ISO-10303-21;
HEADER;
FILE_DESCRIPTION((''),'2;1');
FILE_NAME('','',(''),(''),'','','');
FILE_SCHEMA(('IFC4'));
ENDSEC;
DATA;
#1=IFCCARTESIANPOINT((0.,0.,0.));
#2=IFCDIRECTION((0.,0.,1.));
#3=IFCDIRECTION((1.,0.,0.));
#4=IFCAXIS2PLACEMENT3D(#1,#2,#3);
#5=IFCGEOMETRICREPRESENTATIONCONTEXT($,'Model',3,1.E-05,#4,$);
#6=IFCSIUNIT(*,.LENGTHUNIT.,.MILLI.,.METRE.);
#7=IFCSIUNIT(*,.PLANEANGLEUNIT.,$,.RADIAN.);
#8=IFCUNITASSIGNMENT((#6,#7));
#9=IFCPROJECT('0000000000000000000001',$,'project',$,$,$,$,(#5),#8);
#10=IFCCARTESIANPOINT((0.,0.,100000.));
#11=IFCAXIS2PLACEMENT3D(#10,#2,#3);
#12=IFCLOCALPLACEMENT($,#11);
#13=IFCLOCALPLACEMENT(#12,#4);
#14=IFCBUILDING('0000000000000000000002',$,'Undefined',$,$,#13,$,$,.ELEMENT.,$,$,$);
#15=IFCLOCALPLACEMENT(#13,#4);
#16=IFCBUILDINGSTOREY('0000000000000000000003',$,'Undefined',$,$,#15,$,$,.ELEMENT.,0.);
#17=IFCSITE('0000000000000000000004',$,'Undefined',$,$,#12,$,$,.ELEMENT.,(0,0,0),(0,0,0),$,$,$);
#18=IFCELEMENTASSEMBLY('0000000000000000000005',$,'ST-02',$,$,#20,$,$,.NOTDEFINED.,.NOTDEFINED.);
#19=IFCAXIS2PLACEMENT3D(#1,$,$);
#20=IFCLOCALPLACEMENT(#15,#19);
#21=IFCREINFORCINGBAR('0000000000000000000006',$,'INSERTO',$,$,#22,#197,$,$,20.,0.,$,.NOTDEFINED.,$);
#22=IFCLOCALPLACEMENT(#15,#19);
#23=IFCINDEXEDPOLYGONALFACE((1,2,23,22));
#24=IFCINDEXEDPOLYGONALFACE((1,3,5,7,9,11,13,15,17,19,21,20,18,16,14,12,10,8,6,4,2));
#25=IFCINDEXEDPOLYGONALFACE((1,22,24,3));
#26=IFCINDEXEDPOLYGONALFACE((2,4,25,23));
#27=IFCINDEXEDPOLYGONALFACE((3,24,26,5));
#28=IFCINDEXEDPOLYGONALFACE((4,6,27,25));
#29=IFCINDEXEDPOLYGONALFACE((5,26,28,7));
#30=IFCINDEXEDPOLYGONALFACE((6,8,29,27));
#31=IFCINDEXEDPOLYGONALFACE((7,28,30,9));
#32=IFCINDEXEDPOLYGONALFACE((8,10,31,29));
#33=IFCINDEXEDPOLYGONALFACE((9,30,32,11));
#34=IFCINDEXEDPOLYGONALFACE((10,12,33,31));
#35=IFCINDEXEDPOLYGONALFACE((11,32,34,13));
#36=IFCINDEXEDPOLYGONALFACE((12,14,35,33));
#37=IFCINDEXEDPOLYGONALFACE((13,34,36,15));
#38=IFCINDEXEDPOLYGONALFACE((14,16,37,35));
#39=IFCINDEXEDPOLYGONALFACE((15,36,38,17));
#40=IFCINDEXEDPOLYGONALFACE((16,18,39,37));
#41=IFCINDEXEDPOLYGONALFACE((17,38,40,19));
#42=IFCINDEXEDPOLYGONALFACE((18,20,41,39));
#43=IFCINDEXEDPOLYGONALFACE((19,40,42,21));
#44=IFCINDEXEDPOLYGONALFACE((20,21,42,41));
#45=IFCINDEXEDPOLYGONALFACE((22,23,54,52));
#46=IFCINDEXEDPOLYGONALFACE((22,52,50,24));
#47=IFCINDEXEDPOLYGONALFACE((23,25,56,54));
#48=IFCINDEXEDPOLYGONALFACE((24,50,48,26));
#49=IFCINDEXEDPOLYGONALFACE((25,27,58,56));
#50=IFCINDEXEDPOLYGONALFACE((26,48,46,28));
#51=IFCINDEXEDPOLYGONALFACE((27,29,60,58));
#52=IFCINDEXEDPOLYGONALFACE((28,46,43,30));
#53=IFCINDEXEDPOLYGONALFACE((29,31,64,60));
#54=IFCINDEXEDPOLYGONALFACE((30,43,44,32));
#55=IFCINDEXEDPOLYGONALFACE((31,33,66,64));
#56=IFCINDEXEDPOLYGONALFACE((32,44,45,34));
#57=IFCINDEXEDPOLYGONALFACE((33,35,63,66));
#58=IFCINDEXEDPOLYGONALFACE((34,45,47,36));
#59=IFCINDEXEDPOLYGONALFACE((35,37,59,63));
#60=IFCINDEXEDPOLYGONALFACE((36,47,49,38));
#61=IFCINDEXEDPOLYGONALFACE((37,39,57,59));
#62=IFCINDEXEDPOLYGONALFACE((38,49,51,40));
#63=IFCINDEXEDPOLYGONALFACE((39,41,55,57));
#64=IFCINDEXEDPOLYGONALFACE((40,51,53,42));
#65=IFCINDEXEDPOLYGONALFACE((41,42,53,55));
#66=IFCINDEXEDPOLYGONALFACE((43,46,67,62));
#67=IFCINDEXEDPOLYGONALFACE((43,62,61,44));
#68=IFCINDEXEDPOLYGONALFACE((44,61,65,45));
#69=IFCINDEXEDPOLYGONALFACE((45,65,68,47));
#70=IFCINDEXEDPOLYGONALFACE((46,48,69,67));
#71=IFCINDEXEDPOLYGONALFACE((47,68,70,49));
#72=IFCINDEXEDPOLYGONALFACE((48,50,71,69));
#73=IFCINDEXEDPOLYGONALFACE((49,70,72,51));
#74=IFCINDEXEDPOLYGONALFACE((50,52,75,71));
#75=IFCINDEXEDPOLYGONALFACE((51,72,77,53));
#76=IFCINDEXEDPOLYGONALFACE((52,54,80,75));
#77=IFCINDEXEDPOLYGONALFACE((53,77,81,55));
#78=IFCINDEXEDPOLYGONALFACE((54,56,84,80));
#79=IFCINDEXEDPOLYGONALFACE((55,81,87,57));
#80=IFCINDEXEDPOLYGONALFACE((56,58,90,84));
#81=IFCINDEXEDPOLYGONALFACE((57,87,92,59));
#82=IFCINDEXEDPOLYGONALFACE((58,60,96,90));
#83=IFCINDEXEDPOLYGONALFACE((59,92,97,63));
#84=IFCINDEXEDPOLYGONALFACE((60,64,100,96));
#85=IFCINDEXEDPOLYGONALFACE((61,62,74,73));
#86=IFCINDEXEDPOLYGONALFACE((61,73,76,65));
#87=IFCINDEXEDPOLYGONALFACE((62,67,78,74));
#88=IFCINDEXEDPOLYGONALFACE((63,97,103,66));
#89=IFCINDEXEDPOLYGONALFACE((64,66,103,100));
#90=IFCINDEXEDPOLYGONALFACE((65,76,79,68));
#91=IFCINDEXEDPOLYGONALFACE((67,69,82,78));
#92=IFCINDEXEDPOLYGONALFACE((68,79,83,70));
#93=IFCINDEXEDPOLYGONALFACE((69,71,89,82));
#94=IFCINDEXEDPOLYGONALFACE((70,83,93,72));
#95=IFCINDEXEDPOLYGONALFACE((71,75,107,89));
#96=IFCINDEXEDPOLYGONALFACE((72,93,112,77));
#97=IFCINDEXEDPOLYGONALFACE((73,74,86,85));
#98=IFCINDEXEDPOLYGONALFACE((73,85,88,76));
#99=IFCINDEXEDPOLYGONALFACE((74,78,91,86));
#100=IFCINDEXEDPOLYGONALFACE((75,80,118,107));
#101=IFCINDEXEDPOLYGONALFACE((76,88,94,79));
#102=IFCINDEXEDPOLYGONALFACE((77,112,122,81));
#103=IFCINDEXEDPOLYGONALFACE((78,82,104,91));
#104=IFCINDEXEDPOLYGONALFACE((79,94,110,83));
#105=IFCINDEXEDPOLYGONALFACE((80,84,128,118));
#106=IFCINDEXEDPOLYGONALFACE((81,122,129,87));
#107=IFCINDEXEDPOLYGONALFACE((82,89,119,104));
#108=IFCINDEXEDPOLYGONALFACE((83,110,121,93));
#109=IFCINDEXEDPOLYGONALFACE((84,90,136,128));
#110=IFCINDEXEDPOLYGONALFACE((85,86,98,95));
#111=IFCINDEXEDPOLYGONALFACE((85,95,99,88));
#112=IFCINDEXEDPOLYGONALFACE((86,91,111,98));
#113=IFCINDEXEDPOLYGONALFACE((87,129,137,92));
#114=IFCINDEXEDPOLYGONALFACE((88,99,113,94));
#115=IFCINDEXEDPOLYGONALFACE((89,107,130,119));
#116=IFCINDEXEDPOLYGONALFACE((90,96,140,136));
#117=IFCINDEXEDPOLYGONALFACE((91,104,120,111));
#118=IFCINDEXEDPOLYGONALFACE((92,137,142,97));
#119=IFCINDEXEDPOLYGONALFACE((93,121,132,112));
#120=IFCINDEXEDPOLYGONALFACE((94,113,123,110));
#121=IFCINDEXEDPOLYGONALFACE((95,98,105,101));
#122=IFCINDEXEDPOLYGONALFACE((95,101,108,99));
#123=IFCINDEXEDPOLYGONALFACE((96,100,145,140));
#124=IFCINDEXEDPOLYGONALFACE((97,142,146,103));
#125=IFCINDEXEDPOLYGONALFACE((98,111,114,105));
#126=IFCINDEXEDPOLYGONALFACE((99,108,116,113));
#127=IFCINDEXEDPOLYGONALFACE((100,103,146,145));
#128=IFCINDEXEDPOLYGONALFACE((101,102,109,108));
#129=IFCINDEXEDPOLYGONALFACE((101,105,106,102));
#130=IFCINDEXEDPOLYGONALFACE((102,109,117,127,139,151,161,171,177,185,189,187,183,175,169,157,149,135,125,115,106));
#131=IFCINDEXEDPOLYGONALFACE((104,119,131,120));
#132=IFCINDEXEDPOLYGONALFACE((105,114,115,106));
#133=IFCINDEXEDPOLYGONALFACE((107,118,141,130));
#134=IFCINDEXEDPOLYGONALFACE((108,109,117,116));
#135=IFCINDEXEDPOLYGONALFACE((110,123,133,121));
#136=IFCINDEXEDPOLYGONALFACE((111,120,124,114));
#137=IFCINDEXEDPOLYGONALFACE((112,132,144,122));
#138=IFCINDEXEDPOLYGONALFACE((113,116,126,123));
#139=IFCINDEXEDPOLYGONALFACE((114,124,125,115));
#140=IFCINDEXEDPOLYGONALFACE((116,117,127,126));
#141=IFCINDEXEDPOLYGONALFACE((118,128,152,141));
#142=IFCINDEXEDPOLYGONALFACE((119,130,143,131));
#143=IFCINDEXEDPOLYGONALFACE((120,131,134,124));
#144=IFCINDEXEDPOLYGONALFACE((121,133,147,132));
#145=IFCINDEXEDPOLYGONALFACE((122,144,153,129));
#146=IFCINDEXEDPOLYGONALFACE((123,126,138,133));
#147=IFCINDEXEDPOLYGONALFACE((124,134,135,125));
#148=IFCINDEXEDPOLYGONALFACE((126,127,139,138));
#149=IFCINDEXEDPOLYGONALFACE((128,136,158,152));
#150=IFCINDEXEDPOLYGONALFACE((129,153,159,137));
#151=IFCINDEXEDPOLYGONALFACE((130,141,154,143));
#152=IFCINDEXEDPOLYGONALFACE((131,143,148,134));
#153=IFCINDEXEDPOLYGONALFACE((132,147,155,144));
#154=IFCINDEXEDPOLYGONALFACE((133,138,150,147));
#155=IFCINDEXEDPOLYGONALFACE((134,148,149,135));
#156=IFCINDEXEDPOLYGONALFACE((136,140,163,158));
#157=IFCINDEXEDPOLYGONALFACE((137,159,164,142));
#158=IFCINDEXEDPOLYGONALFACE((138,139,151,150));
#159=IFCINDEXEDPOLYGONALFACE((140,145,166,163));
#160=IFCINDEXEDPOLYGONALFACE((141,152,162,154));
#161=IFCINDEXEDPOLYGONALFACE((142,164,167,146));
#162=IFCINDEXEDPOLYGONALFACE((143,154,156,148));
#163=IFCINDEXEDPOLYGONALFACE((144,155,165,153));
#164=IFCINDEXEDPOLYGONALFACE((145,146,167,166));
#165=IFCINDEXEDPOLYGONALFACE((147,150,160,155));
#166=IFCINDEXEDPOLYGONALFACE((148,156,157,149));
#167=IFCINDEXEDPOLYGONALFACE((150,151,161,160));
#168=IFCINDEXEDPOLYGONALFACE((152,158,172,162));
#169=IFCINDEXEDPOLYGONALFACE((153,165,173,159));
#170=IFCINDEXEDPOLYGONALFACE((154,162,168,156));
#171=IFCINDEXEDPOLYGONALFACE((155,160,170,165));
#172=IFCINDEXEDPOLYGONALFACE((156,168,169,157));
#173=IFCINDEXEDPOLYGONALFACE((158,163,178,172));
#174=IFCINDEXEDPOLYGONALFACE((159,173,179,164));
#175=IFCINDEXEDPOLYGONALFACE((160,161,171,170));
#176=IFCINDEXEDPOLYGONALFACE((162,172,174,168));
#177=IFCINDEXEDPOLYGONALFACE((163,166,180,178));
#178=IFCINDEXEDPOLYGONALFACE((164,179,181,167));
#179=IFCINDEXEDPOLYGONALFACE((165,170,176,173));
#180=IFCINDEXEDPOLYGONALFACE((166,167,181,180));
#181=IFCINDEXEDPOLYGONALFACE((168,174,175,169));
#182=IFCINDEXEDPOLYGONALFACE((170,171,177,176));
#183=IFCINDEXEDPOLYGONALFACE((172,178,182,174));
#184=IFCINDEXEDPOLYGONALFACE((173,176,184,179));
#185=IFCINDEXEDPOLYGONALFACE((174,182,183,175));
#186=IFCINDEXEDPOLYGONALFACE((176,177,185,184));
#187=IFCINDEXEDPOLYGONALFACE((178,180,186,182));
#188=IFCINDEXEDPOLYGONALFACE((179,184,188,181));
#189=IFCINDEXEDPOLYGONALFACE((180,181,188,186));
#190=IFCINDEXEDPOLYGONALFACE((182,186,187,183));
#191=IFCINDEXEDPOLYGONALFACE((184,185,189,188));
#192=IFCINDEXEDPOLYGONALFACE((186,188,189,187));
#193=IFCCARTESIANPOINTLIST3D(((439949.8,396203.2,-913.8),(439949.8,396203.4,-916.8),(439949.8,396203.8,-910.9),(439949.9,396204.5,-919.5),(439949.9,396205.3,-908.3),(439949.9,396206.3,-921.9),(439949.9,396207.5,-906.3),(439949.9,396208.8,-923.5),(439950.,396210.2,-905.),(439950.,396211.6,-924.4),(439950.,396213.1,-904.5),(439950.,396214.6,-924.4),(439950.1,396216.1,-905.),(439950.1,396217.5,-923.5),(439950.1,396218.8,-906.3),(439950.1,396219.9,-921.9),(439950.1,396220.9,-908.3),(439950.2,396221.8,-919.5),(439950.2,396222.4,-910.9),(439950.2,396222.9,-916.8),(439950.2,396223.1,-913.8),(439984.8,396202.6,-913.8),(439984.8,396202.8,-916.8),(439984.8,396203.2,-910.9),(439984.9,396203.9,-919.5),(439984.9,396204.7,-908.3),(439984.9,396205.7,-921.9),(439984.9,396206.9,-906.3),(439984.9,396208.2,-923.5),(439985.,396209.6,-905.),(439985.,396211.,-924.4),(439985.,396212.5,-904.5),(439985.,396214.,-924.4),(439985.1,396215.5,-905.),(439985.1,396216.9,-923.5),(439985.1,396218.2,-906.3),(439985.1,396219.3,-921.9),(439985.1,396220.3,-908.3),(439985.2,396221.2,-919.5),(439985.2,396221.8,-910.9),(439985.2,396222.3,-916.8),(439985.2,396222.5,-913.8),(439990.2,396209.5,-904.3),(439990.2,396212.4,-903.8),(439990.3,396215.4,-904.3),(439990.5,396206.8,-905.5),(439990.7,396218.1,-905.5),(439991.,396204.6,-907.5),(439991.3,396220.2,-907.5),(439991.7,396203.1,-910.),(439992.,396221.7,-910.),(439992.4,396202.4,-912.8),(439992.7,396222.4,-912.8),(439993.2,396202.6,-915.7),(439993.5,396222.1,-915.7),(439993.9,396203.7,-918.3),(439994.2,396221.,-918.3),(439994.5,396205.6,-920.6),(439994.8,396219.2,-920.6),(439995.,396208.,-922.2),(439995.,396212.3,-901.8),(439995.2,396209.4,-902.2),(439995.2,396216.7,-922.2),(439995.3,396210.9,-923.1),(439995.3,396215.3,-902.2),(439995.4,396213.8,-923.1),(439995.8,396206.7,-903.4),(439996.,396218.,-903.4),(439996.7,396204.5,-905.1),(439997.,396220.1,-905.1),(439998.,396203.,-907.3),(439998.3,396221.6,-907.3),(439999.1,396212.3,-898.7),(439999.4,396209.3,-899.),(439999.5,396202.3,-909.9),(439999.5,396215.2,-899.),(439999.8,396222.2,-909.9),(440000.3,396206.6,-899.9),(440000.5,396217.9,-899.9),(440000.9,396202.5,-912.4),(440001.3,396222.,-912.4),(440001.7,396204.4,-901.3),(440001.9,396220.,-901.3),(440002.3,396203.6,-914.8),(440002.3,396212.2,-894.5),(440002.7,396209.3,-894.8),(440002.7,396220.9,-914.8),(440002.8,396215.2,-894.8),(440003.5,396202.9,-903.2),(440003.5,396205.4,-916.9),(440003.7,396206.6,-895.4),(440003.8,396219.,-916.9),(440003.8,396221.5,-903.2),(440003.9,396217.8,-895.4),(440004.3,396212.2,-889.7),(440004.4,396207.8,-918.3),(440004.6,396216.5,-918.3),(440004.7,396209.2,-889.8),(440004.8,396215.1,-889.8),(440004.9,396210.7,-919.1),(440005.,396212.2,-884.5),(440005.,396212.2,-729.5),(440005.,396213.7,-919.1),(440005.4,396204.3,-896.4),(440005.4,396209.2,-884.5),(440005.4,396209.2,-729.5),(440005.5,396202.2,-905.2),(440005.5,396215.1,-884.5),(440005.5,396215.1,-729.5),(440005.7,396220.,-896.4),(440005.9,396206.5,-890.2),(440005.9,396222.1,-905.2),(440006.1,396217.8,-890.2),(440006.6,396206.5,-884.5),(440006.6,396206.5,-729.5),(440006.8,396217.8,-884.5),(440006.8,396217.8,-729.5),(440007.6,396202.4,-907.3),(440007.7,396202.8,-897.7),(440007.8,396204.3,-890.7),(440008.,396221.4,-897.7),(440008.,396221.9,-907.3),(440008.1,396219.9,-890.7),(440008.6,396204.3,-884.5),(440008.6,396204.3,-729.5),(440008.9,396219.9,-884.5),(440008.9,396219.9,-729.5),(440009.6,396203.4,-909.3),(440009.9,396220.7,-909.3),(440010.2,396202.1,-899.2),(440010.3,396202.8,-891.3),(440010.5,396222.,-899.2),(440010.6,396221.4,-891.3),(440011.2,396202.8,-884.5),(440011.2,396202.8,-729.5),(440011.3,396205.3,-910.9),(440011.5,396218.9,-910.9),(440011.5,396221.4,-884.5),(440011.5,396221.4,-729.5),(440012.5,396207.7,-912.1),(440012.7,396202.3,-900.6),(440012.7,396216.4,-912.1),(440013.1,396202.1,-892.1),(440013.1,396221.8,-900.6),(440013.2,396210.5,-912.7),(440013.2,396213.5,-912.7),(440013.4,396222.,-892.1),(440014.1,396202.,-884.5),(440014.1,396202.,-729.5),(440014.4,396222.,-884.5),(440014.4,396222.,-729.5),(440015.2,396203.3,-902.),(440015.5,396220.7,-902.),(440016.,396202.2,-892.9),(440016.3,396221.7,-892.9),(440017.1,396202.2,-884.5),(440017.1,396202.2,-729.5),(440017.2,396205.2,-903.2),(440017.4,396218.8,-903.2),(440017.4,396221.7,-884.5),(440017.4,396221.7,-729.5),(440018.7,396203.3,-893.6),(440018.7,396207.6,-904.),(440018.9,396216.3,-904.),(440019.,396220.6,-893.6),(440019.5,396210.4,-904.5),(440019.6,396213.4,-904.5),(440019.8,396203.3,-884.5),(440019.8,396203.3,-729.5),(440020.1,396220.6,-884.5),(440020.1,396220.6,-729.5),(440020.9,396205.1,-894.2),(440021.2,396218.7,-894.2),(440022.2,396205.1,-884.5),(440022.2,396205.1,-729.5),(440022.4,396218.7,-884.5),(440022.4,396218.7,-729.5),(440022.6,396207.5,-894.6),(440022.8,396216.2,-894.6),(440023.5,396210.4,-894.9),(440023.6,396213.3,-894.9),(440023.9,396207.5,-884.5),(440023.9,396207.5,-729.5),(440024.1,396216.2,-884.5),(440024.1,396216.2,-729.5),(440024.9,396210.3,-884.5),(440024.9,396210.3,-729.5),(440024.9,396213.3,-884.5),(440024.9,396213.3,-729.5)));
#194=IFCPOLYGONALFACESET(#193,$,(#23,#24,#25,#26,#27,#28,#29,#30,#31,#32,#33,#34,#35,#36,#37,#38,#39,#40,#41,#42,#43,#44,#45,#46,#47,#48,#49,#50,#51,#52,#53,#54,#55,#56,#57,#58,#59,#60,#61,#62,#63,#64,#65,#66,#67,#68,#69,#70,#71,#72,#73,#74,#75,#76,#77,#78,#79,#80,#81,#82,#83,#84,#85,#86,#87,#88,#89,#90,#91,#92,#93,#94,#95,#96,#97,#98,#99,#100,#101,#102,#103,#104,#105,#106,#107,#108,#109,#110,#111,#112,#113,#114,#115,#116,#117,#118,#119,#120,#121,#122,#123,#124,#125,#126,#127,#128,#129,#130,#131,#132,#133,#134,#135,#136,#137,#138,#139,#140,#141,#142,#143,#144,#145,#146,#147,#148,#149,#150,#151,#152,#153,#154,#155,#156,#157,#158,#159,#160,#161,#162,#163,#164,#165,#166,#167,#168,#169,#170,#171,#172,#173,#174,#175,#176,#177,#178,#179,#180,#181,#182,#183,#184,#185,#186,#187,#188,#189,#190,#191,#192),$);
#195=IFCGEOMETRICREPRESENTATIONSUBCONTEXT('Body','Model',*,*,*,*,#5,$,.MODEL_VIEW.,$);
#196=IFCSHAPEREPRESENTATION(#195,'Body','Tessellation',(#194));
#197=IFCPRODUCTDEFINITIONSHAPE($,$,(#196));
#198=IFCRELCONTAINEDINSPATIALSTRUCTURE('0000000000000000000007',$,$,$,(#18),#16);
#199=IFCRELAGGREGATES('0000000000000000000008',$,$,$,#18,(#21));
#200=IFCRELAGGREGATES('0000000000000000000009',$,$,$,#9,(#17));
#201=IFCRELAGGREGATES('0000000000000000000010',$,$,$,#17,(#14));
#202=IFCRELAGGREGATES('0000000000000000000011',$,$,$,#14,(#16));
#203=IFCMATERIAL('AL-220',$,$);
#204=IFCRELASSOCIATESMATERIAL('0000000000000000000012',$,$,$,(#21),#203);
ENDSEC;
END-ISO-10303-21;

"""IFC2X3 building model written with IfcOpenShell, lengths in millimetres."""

from ifc_helpers import new_model, entity, si_unit, frame, origin_with_axes, place, context, subcontext, project, spatial, source, transform, mapped, material, element, aggregate, save


model = new_model("IFC2X3")

# Units and contexts
model_context = context("Model", 3, precision=1e-05, world=origin_with_axes())
body_context = subcontext(model_context, "Body", "Model", "MODEL_VIEW")
ifc_project = project(units=[si_unit("LENGTHUNIT", "METRE", prefix="MILLI"), si_unit("PLANEANGLEUNIT", "RADIAN")], contexts=[model_context])

# Site, building, storey
site_placement = place(None, frame((0.0, 0.0, 100000.0), z_axis=(0.0, 0.0, 1.0), x_axis=(1.0, 0.0, 0.0)))
site = spatial("IfcSite", under=ifc_project, at=site_placement, Name="Undefined", CompositionType="ELEMENT", RefLatitude=(0, 0, 0), RefLongitude=(0, 0, 0))
building_placement = place(site_placement, origin_with_axes())
building = spatial("IfcBuilding", under=site, at=building_placement, Name="Undefined", CompositionType="ELEMENT")
storey_placement = place(building_placement, origin_with_axes())
storey = spatial("IfcBuildingStorey", under=building, at=storey_placement, Name="Undefined", CompositionType="ELEMENT", Elevation=0.0)

# Element assembly
assembly_1_placement = place(storey_placement, origin_with_axes())
assembly_1 = element("IfcElementAssembly", 1, at=assembly_1_placement, inside=storey, Name="ST-02", AssemblyPlace="NOTDEFINED", PredefinedType="NOTDEFINED")

# Reinforcing bar
ifc_material_1 = material(Name="AL-220")
shared_shape_1 = source(origin_with_axes(), body_context, "Body", "AdvancedSweptSolid", [
    entity("IfcSweptDiskSolid", entity("IfcCompositeCurve", [entity("IfcCompositeCurveSegment", "CONTINUOUS", True, entity("IfcTrimmedCurve", entity("IfcLine", entity("IfcCartesianPoint", [0.0, 0.0, 0.0]), entity("IfcVector", entity("IfcDirection", [1.0, 0.0, 0.0]), 1.0)), [entity("IfcParameterValue", 0.0)], [entity("IfcParameterValue", 155.0)], True, "PARAMETER")), entity("IfcCompositeCurveSegment", "CONTINUOUS", True, entity("IfcTrimmedCurve", entity("IfcCircle", entity("IfcAxis2Placement3D", entity("IfcCartesianPoint", [155.0, 0.0, 30.0]), entity("IfcDirection", [0.0, -1.0, 0.0]), entity("IfcDirection", [0.0, 0.0, -1.0])), 30.0), [entity("IfcParameterValue", 0.0)], [entity("IfcParameterValue", 1.570796)], True, "PARAMETER")), entity("IfcCompositeCurveSegment", "DISCONTINUOUS", True, entity("IfcTrimmedCurve", entity("IfcLine", entity("IfcCartesianPoint", [185.0, 0.0, 30.0]), entity("IfcVector", entity("IfcDirection", [0.0, 0.0, 1.0]), 1.0)), [entity("IfcParameterValue", 0.0)], [entity("IfcParameterValue", 35.0)], True, "PARAMETER"))], False), 10.0, None, 0.0, 191.6),
])
reinforcing_bar_1_placement = place(assembly_1_placement, frame((440015.0, 396212.0, -729.5), z_axis=(-0.999848, 0.017452, 0.0), x_axis=(0.0, 0.0, -1.0)))
reinforcing_bar_1 = element("IfcReinforcingBar", 2, at=reinforcing_bar_1_placement, material=ifc_material_1, Name="INSERTO", BarRole="NOTDEFINED", CrossSectionArea=0.0, NominalDiameter=20.0, context=body_context, shape_type="MappedRepresentation", body=[
    mapped(shared_shape_1, transform((0.0, 0.0, 0.0))),
])
aggregate(assembly_1, [reinforcing_bar_1])

save(model, "model.ifc")
